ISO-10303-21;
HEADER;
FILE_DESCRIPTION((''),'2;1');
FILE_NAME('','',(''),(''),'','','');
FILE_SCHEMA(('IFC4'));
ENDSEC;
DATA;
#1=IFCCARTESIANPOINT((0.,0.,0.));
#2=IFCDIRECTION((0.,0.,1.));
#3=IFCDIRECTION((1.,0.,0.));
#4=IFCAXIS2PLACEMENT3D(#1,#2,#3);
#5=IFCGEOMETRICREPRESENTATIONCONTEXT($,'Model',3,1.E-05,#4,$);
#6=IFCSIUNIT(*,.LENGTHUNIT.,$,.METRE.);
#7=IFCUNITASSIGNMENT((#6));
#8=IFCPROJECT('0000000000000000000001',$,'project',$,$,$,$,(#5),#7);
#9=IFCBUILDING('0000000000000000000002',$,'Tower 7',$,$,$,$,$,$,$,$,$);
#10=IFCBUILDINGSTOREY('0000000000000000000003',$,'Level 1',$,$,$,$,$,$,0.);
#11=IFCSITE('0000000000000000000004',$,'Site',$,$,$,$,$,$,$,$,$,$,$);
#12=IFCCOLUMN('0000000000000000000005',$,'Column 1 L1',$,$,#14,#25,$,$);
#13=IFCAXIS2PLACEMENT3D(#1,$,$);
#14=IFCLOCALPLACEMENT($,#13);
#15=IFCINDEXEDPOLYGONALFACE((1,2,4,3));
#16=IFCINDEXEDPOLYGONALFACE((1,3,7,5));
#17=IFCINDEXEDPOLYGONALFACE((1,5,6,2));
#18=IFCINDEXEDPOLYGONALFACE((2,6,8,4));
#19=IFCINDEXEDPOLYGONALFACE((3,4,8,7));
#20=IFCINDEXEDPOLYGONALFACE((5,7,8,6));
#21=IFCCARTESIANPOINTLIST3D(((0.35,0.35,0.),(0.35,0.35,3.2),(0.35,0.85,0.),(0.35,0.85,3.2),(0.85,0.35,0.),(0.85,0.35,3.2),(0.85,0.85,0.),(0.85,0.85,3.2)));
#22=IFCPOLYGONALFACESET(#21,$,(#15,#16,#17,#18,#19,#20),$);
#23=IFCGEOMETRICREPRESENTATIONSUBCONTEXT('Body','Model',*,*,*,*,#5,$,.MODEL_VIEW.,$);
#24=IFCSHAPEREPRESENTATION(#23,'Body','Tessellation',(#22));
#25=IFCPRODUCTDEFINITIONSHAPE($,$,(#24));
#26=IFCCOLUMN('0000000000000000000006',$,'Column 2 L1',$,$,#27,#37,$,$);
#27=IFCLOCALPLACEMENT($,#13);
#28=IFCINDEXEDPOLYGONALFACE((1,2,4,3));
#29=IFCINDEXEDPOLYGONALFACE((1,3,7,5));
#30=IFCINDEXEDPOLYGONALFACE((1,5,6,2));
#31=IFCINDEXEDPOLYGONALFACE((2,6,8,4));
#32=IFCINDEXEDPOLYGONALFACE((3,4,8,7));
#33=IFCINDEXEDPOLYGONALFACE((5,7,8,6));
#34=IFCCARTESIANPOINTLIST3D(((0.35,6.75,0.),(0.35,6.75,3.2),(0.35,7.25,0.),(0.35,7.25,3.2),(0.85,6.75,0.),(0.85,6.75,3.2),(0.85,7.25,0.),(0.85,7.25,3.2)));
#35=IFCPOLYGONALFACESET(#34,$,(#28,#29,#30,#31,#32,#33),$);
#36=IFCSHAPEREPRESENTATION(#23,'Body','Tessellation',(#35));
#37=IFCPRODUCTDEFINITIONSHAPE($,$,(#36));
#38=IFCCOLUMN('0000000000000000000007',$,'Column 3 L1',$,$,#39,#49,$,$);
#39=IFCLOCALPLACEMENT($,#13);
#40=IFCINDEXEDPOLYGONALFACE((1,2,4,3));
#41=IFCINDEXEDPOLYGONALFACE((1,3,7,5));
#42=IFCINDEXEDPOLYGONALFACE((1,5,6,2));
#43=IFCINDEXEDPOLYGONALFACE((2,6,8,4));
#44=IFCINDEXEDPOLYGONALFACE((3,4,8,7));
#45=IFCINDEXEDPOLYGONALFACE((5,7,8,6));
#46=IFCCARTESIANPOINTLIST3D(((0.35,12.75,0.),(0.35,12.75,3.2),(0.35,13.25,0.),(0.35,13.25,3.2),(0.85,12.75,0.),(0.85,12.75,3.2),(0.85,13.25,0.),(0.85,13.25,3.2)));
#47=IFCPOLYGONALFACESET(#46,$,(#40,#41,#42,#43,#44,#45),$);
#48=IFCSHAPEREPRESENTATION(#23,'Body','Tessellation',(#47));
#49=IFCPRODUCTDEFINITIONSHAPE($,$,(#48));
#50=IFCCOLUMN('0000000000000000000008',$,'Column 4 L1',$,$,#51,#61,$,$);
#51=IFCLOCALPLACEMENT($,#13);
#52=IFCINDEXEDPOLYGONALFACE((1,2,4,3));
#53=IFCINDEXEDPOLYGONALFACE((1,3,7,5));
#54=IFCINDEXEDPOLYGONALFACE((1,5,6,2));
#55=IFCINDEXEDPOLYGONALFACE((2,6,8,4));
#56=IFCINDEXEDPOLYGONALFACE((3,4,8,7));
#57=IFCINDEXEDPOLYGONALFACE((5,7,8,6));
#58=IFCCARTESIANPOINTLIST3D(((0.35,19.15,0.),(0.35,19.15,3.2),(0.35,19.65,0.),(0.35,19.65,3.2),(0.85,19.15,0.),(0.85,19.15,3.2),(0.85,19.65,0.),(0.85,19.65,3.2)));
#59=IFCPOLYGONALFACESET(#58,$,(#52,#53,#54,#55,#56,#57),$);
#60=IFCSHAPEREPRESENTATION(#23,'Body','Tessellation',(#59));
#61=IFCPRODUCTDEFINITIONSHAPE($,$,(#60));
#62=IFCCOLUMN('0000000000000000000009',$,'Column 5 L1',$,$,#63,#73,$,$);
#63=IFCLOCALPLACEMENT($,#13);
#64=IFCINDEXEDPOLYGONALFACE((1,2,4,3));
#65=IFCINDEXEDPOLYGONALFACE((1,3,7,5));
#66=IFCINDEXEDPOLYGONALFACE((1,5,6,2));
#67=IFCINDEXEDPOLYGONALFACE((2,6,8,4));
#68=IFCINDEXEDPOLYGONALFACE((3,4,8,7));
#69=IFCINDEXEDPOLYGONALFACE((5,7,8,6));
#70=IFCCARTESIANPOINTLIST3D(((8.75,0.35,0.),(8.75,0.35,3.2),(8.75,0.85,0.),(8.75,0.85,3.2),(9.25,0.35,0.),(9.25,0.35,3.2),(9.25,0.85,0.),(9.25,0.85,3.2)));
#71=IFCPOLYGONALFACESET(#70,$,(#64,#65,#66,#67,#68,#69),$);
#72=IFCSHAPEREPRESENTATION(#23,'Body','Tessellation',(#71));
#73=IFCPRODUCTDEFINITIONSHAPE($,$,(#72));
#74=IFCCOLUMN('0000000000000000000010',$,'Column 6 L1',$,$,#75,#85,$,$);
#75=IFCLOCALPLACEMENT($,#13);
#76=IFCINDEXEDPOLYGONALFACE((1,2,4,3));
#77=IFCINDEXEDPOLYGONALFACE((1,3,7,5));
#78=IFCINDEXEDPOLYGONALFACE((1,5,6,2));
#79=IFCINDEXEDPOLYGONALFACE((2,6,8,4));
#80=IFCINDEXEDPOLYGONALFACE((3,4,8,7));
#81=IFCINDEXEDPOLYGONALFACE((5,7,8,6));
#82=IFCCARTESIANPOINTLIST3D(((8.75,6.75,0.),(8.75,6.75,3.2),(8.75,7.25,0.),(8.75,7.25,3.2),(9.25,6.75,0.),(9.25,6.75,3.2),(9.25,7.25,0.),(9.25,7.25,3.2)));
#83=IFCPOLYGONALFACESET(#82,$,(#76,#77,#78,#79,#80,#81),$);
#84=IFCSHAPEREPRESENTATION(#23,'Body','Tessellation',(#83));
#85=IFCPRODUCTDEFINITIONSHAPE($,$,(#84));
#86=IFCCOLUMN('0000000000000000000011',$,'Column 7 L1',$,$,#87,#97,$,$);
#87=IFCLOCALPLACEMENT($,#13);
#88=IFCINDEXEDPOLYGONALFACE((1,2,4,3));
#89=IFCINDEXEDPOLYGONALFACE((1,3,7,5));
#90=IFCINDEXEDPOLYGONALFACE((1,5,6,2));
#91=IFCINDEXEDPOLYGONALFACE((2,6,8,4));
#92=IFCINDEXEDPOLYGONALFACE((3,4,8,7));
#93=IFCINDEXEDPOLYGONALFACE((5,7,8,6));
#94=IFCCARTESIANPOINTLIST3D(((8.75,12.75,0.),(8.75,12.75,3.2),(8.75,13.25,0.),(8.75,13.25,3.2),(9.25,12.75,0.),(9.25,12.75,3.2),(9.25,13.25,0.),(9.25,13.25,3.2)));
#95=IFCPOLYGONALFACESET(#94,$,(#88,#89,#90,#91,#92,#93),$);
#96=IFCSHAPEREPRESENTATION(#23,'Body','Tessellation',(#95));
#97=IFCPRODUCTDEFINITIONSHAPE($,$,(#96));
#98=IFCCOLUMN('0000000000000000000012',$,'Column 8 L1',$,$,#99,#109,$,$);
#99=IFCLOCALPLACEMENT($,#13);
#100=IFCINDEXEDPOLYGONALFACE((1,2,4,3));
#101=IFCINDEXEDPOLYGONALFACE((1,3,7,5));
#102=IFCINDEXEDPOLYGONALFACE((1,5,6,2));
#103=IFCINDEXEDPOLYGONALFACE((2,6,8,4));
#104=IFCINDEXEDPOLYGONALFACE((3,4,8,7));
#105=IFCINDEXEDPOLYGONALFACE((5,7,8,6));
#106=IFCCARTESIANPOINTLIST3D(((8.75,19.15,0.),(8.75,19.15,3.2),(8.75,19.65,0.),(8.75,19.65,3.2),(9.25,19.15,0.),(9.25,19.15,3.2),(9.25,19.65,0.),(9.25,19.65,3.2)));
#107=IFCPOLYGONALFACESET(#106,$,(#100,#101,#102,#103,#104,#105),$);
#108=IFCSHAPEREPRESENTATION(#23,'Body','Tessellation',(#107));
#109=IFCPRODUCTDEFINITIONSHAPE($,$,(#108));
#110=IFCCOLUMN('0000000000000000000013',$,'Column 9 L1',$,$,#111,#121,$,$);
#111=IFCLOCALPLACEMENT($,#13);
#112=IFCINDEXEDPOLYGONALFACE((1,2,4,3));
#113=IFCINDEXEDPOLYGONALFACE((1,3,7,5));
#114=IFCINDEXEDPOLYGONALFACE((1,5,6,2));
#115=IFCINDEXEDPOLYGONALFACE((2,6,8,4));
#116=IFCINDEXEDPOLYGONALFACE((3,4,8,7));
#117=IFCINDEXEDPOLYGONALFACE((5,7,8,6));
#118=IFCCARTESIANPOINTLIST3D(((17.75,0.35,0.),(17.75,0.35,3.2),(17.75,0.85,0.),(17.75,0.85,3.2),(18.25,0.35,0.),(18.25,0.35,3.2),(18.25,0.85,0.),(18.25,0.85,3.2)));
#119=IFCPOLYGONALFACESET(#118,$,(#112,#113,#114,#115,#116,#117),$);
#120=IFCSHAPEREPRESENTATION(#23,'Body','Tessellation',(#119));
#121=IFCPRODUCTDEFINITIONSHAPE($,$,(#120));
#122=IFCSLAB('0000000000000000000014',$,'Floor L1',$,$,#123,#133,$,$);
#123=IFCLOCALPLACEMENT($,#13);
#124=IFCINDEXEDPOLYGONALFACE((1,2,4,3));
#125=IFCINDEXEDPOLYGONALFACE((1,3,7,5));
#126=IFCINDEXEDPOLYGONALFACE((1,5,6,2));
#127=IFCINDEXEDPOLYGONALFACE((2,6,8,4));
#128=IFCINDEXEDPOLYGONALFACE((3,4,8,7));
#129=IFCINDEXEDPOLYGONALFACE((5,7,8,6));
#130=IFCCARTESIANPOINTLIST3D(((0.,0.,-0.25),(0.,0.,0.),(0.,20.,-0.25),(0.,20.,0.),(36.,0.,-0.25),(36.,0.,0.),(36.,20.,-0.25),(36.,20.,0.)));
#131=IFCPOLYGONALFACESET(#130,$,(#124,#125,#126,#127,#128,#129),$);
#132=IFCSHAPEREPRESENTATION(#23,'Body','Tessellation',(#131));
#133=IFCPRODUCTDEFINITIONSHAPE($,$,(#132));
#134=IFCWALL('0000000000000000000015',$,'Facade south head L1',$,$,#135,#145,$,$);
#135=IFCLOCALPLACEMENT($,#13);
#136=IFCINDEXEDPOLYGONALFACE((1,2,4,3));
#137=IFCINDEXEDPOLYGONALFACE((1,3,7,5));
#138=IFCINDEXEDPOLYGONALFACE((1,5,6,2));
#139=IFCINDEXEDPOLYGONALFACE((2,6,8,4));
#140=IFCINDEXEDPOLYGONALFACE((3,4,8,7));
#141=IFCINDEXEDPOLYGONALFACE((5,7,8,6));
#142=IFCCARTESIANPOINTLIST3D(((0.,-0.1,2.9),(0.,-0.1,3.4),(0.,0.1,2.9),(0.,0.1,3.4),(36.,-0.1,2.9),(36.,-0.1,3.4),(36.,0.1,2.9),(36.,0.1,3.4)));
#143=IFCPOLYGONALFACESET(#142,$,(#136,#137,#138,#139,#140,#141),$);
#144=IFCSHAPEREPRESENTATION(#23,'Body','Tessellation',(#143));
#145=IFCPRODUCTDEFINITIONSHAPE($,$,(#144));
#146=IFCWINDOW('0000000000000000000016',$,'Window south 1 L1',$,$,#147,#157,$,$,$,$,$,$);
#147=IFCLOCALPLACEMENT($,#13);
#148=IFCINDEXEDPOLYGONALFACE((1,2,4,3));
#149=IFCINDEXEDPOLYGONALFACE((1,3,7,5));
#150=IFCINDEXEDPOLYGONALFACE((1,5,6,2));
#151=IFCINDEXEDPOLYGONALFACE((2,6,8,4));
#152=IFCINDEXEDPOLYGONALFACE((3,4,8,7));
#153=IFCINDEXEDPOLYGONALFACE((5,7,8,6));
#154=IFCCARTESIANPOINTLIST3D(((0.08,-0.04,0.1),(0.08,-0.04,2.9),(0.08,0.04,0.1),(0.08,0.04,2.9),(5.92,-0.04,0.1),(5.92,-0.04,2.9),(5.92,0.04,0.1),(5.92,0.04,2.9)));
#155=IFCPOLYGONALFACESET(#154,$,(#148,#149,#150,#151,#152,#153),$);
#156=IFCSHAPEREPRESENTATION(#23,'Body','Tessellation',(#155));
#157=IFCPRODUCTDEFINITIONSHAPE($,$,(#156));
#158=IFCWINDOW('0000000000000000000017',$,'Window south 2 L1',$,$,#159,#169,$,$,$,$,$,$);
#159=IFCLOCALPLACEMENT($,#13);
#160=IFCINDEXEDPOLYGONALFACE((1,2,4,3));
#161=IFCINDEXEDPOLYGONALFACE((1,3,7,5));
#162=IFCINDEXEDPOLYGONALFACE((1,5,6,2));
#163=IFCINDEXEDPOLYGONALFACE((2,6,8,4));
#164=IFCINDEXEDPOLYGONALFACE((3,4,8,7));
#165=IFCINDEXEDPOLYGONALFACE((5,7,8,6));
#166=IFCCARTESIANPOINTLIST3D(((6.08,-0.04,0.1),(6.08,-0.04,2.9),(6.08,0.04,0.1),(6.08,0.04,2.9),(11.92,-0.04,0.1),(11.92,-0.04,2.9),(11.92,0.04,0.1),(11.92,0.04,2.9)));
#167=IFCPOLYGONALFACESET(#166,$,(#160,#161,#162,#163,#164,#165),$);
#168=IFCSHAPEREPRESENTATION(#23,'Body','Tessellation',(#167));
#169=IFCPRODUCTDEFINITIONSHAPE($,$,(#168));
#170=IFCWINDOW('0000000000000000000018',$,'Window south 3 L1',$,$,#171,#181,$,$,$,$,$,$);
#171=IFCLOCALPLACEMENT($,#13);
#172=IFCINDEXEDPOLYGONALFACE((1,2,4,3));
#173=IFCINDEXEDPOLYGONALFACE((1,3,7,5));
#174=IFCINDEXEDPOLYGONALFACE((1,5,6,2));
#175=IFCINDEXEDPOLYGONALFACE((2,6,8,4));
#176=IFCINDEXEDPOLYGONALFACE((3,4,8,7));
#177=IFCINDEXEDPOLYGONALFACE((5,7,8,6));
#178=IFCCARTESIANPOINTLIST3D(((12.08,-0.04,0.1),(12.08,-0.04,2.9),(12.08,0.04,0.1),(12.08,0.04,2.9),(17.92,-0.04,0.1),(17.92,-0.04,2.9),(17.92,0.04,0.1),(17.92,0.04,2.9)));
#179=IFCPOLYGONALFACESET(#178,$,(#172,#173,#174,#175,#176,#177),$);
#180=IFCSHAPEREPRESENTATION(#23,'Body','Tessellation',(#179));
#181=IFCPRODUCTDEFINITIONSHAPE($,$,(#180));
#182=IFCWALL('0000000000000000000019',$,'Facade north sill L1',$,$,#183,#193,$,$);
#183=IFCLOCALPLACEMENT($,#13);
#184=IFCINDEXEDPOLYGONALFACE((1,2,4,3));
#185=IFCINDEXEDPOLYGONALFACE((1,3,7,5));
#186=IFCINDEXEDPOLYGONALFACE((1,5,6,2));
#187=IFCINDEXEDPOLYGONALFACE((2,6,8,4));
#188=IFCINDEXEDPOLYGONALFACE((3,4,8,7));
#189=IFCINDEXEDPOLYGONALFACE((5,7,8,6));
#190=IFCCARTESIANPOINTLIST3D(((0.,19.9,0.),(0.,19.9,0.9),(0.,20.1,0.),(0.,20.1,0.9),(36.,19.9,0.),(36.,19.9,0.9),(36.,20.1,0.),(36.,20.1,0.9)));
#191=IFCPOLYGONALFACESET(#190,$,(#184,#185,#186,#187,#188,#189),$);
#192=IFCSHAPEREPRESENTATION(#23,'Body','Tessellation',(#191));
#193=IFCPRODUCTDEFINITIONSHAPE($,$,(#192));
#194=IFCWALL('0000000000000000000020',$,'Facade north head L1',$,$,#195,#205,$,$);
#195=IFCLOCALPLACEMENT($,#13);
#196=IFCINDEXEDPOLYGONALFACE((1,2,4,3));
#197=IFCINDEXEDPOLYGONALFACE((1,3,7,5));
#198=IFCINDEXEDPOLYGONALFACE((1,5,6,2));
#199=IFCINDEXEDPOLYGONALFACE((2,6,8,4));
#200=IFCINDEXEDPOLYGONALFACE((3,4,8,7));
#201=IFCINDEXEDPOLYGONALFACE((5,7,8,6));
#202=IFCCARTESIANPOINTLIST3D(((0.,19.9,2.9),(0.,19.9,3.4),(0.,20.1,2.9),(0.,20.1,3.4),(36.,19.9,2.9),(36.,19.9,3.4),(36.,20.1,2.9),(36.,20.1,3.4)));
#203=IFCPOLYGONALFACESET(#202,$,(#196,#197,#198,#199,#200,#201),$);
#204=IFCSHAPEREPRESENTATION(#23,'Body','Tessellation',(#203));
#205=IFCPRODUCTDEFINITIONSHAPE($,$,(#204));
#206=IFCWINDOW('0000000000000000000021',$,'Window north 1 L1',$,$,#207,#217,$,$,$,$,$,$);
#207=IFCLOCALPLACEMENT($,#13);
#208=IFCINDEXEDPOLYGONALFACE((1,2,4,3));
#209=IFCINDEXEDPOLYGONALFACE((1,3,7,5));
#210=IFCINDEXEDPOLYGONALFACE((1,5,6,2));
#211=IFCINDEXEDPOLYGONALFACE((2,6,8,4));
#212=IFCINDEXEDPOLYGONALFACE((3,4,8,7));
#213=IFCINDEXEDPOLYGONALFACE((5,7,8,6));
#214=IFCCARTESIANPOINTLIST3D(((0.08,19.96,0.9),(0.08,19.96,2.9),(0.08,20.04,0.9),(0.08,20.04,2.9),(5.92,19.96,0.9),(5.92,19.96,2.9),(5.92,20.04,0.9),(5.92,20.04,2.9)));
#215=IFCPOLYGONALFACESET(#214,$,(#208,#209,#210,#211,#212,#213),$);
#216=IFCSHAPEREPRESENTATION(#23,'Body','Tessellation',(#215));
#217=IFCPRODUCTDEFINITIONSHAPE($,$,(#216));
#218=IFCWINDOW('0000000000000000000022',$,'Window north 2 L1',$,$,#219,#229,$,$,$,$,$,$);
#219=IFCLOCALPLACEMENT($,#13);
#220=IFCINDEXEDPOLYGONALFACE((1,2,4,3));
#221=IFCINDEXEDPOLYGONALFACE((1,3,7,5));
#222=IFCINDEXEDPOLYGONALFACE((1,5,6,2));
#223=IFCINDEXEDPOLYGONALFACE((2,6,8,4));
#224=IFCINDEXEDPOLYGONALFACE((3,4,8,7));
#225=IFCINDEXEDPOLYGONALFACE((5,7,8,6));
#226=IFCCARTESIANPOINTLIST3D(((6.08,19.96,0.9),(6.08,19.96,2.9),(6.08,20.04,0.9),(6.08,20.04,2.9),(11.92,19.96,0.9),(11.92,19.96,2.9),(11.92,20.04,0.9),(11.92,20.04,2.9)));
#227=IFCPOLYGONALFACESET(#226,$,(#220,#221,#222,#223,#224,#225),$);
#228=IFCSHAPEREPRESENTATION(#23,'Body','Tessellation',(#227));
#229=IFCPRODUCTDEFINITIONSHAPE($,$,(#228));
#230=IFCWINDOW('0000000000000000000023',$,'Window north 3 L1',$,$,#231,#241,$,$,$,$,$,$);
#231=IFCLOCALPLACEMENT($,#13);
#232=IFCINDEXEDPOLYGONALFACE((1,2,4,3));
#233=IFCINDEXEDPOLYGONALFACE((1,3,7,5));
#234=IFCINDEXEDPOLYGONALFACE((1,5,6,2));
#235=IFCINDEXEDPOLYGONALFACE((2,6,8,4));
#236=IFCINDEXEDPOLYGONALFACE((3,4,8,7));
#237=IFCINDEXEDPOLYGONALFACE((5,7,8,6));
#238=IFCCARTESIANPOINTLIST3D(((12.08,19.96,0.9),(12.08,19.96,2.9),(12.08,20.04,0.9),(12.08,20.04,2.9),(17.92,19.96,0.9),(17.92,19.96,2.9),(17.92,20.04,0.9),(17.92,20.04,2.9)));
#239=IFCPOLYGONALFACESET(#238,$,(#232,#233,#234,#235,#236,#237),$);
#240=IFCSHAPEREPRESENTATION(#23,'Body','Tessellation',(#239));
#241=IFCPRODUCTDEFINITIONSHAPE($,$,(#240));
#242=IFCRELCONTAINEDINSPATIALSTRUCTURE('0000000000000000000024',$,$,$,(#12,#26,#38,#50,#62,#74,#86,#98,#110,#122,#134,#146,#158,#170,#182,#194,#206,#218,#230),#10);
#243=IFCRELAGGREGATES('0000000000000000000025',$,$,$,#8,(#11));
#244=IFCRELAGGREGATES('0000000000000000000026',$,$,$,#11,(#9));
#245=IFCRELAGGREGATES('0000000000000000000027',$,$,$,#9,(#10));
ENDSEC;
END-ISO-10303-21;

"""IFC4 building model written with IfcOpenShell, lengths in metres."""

from ifc_helpers import new_model, si_unit, frame, origin, origin_with_axes, origin_2d, place, context, subcontext, project, spatial, rectangle, extrude, element, save


model = new_model("IFC4")

# Units and contexts
model_context = context("Model", 3, precision=1e-05, world=origin_with_axes())
body_context = subcontext(model_context, "Body", "Model", "MODEL_VIEW")
ifc_project = project(units=[si_unit("LENGTHUNIT", "METRE")], contexts=[model_context])

# Site, building, storey
site = spatial("IfcSite", under=ifc_project, Name="Site")
building = spatial("IfcBuilding", under=site, Name="Tower 7")
storey = spatial("IfcBuildingStorey", under=building, Name="Level 1", Elevation=0.0)

# Columns
for number, where, z_axis, x_axis, name in (
    (1, (0.6, 0.6, 0.0), (0.0, 0.0, 1.0), (1.0, 0.0, 0.0), "Column 1 L1"),
    (2, (0.6, 7.0, 0.0), (0.0, 0.0, 1.0), (1.0, 0.0, 0.0), "Column 2 L1"),
    (3, (0.6, 13.0, 0.0), (0.0, 0.0, 1.0), (1.0, 0.0, 0.0), "Column 3 L1"),
    (4, (0.6, 19.4, 0.0), (0.0, 0.0, 1.0), (1.0, 0.0, 0.0), "Column 4 L1"),
    (5, (9.0, 0.6, 0.0), (0.0, 0.0, 1.0), (1.0, 0.0, 0.0), "Column 5 L1"),
    (6, (9.0, 7.0, 0.0), (0.0, 0.0, 1.0), (1.0, 0.0, 0.0), "Column 6 L1"),
    (7, (9.0, 13.0, 0.0), (0.0, 0.0, 1.0), (1.0, 0.0, 0.0), "Column 7 L1"),
    (8, (9.0, 19.4, 0.0), (0.0, 0.0, 1.0), (1.0, 0.0, 0.0), "Column 8 L1"),
    (9, (18.0, 0.6, 0.0), (0.0, 0.0, 1.0), (1.0, 0.0, 0.0), "Column 9 L1"),
):
    element("IfcColumn", number, at=place(None, frame(where, z_axis=z_axis, x_axis=x_axis)), inside=storey, Name=name, context=body_context, shape_type="SweptSolid", body=[
        extrude(rectangle(XDim=0.5, YDim=0.5, at=origin_2d()), origin(), (0.0, 0.0, 1.0), 3.2),
    ])

# Slab
slab_placement = place(None, frame((18.0, 10.0, -0.25), z_axis=(0.0, 0.0, 1.0), x_axis=(1.0, 0.0, 0.0)))
element("IfcSlab", 10, at=slab_placement, inside=storey, Name="Floor L1", context=body_context, shape_type="SweptSolid", body=[
    extrude(rectangle(XDim=36.0, YDim=20.0, at=origin_2d()), origin(), (0.0, 0.0, 1.0), 0.25),
])

# Wall
wall_1_placement = place(None, frame((18.0, 0.0, 2.9), z_axis=(0.0, 0.0, 1.0), x_axis=(1.0, 0.0, 0.0)))
element("IfcWall", 11, at=wall_1_placement, inside=storey, Name="Facade south head L1", context=body_context, shape_type="SweptSolid", body=[
    extrude(rectangle(XDim=36.0, YDim=0.2, at=origin_2d()), origin(), (0.0, 0.0, 1.0), 0.5),
])

# Windows
for number, where, z_axis, x_axis, name in (
    (12, (3.0, 0.0, 0.1), (0.0, 0.0, 1.0), (1.0, 0.0, 0.0), "Window south 1 L1"),
    (13, (9.0, 0.0, 0.1), (0.0, 0.0, 1.0), (1.0, 0.0, 0.0), "Window south 2 L1"),
):
    element("IfcWindow", number, at=place(None, frame(where, z_axis=z_axis, x_axis=x_axis)), inside=storey, Name=name, context=body_context, shape_type="SweptSolid", body=[
        extrude(rectangle(XDim=5.84, YDim=0.08, at=origin_2d()), origin(), (0.0, 0.0, 1.0), 2.8),
    ])
window_1_placement = place(None, frame((15.0, 0.0, 0.1), z_axis=(0.0, 0.0, 1.0), x_axis=(1.0, 0.0, 0.0)))
element("IfcWindow", 14, at=window_1_placement, inside=storey, Name="Window south 3 L1", context=body_context, shape_type="SweptSolid", body=[
    extrude(rectangle(XDim=5.84, YDim=0.08, at=origin_2d()), origin(), (0.0, 0.0, 1.0), 2.8),
])

# Walls
wall_2_placement = place(None, frame((18.0, 20.0, 0.0), z_axis=(0.0, 0.0, 1.0), x_axis=(1.0, 0.0, 0.0)))
element("IfcWall", 15, at=wall_2_placement, inside=storey, Name="Facade north sill L1", context=body_context, shape_type="SweptSolid", body=[
    extrude(rectangle(XDim=36.0, YDim=0.2, at=origin_2d()), origin(), (0.0, 0.0, 1.0), 0.9),
])
wall_3_placement = place(None, frame((18.0, 20.0, 2.9), z_axis=(0.0, 0.0, 1.0), x_axis=(1.0, 0.0, 0.0)))
element("IfcWall", 16, at=wall_3_placement, inside=storey, Name="Facade north head L1", context=body_context, shape_type="SweptSolid", body=[
    extrude(rectangle(XDim=36.0, YDim=0.2, at=origin_2d()), origin(), (0.0, 0.0, 1.0), 0.5),
])

# Windows
for number, where, z_axis, x_axis, name in (
    (17, (3.0, 20.0, 0.9), (0.0, 0.0, 1.0), (1.0, 0.0, 0.0), "Window north 1 L1"),
    (18, (9.0, 20.0, 0.9), (0.0, 0.0, 1.0), (1.0, 0.0, 0.0), "Window north 2 L1"),
):
    element("IfcWindow", number, at=place(None, frame(where, z_axis=z_axis, x_axis=x_axis)), inside=storey, Name=name, context=body_context, shape_type="SweptSolid", body=[
        extrude(rectangle(XDim=5.84, YDim=0.08, at=origin_2d()), origin(), (0.0, 0.0, 1.0), 2.0),
    ])
window_2_placement = place(None, frame((15.0, 20.0, 0.9), z_axis=(0.0, 0.0, 1.0), x_axis=(1.0, 0.0, 0.0)))
element("IfcWindow", 19, at=window_2_placement, inside=storey, Name="Window north 3 L1", context=body_context, shape_type="SweptSolid", body=[
    extrude(rectangle(XDim=5.84, YDim=0.08, at=origin_2d()), origin(), (0.0, 0.0, 1.0), 2.0),
])

save(model, "model.ifc")
